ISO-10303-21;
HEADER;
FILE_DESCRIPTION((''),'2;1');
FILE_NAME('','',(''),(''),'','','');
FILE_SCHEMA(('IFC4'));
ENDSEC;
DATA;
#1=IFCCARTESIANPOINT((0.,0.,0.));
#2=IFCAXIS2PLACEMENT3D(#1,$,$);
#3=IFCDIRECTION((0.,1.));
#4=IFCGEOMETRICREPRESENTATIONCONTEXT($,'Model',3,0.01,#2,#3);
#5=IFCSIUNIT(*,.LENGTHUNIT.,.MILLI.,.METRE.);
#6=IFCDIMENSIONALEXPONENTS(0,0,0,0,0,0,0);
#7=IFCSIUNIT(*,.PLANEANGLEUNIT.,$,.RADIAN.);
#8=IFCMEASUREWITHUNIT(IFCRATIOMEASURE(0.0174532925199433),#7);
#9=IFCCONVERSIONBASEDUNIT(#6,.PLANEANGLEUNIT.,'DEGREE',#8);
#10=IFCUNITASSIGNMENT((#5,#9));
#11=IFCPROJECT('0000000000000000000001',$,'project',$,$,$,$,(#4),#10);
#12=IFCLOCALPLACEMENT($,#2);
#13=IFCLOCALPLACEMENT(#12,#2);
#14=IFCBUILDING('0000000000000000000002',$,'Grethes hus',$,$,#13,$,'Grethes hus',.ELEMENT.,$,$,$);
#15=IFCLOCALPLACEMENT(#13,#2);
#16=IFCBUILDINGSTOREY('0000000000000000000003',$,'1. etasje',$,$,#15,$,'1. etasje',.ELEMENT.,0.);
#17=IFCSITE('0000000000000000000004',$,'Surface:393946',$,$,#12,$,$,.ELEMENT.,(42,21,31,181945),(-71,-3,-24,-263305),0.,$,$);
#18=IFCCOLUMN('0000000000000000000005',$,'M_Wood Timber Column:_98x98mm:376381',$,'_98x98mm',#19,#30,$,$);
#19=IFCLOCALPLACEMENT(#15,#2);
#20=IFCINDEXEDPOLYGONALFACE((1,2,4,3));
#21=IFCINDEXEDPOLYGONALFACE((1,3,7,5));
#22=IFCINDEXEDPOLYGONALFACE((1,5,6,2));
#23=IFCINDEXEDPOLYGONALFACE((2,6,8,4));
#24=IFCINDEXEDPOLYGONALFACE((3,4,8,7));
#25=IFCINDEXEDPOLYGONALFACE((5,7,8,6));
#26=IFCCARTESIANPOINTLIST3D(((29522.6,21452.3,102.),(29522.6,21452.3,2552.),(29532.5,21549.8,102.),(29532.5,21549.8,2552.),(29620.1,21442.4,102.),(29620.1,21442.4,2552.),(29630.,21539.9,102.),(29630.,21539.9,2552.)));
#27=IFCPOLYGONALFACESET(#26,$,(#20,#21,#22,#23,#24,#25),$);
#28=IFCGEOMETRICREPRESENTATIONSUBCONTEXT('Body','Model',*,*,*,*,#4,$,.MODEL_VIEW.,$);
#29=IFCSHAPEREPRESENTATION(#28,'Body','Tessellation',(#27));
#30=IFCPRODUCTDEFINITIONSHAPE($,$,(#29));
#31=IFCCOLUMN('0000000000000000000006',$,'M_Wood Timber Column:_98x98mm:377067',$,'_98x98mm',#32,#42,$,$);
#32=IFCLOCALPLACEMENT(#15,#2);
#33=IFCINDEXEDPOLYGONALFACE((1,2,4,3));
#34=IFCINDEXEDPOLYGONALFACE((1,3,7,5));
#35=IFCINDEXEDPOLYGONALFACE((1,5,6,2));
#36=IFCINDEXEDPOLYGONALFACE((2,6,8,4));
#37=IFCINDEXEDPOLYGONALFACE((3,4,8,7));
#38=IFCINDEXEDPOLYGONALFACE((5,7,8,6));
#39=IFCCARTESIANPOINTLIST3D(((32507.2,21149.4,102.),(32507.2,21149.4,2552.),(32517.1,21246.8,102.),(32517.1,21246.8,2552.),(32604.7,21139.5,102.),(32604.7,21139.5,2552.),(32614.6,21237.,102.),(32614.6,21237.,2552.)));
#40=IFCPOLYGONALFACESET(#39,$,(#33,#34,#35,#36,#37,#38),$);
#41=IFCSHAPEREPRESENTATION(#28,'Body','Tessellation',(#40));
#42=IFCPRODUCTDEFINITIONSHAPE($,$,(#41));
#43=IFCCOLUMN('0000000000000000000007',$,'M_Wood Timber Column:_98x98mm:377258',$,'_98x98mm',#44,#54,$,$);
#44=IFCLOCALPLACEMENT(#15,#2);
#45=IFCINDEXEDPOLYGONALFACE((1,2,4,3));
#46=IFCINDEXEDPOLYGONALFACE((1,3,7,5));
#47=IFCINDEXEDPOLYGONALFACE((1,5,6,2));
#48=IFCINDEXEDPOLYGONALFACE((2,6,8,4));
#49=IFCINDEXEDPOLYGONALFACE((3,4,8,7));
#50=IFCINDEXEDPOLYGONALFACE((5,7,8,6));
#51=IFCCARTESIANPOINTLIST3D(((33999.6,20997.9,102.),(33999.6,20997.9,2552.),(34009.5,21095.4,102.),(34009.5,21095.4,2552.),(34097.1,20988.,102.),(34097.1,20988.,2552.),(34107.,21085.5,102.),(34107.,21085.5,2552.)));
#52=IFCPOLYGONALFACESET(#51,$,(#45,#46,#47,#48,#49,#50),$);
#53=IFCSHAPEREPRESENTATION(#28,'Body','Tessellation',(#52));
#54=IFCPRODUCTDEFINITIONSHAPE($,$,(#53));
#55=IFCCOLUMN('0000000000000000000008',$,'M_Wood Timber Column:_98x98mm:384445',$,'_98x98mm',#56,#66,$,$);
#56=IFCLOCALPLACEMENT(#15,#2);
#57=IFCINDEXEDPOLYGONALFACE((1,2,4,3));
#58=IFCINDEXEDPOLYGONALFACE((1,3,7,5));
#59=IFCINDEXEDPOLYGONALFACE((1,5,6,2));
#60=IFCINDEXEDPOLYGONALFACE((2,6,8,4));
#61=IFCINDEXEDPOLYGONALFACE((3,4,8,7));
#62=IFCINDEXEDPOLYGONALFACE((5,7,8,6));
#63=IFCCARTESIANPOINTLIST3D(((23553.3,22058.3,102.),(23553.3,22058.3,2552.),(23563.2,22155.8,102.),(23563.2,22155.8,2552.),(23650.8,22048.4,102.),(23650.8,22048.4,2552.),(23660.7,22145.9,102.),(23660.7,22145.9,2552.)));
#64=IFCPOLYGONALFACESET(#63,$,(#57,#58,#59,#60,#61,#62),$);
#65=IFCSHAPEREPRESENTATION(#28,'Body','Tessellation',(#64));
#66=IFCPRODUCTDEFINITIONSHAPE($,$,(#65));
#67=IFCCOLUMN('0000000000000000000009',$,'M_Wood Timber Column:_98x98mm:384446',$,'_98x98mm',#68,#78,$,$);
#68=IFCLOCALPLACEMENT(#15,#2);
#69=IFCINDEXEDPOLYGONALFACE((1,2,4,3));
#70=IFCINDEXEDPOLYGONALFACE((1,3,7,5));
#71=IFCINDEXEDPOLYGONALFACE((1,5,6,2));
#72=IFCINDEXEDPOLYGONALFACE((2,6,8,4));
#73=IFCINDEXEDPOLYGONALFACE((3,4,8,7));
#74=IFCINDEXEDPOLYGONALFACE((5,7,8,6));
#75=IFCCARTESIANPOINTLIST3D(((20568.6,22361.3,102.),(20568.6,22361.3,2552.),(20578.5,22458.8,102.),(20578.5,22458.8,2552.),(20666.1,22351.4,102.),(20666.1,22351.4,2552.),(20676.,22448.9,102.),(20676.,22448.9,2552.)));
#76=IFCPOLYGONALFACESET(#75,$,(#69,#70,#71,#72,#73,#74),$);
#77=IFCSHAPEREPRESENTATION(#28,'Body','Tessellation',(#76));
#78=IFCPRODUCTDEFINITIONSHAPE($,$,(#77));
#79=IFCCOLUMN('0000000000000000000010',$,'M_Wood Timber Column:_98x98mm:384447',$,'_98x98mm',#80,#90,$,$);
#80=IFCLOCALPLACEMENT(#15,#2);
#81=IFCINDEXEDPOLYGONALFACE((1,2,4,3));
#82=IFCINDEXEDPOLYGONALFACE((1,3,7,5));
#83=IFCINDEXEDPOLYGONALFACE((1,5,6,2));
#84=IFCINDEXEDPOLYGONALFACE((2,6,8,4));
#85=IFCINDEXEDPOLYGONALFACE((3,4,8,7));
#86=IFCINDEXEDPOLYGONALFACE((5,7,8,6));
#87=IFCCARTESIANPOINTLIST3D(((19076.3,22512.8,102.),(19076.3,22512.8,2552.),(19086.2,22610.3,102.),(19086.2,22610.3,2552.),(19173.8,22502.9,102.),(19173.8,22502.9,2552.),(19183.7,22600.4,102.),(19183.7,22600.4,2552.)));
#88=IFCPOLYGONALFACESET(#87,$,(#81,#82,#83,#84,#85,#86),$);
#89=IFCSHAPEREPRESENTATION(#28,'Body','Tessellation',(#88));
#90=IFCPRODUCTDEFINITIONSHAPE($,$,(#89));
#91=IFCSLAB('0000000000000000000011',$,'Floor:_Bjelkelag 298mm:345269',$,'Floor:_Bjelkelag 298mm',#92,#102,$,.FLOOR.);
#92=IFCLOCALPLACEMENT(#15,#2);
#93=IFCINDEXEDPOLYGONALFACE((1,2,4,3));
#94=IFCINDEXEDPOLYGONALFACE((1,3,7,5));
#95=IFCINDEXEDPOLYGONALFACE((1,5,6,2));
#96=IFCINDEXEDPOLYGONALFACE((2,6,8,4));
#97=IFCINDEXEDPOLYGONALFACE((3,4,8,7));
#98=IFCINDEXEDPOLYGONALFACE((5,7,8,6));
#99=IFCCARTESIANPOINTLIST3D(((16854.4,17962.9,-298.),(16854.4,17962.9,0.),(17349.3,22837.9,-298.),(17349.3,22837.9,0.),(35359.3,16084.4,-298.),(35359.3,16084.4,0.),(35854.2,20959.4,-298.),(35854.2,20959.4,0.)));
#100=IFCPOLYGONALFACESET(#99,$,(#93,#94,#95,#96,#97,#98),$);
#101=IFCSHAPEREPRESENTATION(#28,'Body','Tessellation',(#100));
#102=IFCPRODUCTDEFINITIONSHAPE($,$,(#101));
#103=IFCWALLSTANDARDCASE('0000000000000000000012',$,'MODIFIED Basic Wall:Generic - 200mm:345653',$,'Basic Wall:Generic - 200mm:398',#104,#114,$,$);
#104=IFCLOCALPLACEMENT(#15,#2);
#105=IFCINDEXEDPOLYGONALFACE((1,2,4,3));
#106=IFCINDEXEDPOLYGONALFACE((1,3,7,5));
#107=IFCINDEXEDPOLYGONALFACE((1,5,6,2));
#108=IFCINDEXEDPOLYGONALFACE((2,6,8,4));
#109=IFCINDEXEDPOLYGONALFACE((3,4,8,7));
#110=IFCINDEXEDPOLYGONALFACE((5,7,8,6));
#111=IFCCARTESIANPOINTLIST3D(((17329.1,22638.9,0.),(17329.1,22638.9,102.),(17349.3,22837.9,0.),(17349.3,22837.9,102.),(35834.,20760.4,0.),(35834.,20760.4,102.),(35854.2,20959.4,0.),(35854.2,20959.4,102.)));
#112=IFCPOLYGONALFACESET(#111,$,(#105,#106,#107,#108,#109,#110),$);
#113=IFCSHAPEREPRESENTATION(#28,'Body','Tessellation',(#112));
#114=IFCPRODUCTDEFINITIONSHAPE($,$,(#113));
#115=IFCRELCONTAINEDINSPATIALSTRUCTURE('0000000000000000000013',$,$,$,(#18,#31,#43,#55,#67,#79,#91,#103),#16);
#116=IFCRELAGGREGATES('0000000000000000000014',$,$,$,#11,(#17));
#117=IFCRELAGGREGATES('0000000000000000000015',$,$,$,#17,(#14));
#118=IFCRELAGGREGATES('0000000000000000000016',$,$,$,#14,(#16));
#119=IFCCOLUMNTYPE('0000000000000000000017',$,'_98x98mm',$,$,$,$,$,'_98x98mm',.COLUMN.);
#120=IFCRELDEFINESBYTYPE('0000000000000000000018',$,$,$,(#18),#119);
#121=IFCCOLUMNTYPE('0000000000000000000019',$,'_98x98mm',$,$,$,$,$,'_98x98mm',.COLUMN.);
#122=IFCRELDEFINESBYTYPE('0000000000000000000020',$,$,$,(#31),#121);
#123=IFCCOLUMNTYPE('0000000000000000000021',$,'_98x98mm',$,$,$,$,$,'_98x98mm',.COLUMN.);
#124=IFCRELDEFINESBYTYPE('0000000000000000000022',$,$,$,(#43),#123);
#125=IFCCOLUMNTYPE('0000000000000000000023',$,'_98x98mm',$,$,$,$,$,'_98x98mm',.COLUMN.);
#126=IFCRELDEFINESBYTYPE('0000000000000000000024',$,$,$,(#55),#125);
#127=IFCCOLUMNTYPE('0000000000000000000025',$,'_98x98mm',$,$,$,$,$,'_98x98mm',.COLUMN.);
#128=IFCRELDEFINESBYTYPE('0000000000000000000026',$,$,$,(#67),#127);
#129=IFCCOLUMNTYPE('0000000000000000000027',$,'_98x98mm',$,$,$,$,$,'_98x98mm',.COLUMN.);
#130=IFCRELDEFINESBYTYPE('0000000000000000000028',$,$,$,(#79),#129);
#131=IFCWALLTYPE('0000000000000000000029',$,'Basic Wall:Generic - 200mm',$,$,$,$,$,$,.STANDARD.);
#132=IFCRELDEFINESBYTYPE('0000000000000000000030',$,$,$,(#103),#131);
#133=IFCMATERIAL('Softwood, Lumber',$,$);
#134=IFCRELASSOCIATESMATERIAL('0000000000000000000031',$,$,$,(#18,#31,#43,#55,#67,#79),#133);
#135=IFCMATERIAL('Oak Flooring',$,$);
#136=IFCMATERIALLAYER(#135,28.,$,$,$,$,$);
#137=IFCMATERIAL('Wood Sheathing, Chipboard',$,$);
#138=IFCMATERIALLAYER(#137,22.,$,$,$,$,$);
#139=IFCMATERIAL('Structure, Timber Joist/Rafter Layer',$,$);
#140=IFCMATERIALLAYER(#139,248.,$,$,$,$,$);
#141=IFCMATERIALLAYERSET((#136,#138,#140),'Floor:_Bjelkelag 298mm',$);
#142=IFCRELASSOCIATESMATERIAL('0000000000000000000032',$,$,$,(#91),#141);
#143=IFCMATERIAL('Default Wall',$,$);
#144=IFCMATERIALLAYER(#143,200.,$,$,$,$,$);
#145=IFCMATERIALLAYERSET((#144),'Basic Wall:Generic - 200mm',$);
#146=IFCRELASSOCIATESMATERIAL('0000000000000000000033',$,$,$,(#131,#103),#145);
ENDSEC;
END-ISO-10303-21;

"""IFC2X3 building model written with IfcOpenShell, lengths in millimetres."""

from ifc_helpers import new_model, entity, si_unit, converted_unit, direction, frame, frame_2d, origin, place, context, subcontext, project, spatial, rectangle, extrude, source, transform, mapped, material, layer, layer_set, layer_usage, type_object, type_shapes, element, save


model = new_model("IFC2X3")

# Units and contexts
model_context = context("Model", 3, precision=0.01, world=origin(), true_north=direction((0.0, 1.0)))
body_context = subcontext(model_context, "Body", "Model", "MODEL_VIEW")
ifc_project = project(units=[si_unit("LENGTHUNIT", "METRE", prefix="MILLI"), converted_unit("PLANEANGLEUNIT", "DEGREE", entity("IfcRatioMeasure", 0.0174532925199433), si_unit("PLANEANGLEUNIT", "RADIAN"), dimensions=[0, 0, 0, 0, 0, 0, 0])], contexts=[model_context])

# Site, building, storey
site_placement = place(None, origin())
site = spatial("IfcSite", under=ifc_project, at=site_placement, Name="Surface:393946", CompositionType="ELEMENT", RefLatitude=(42, 21, 31, 181945), RefLongitude=(-71, -3, -24, -263305), RefElevation=0.0)
building_placement = place(site_placement, origin())
building = spatial("IfcBuilding", under=site, at=building_placement, Name="Grethes hus", LongName="Grethes hus", CompositionType="ELEMENT")
storey_placement = place(building_placement, origin())
storey = spatial("IfcBuildingStorey", under=building, at=storey_placement, Name="1. etasje", LongName="1. etasje", CompositionType="ELEMENT", Elevation=0.0)

# Columns
ifc_material_1 = material(Name="Softwood, Lumber")
column_type_1 = type_object("IfcColumnType", Name="_98x98mm", ElementType="_98x98mm", PredefinedType="COLUMN")
shared_shape_1 = source(origin(), body_context, "Body", "SweptSolid", [
    extrude(rectangle(XDim=98.0, YDim=98.0, at=frame_2d((0.0, 0.0), x_axis=(1.0, 0.0))), frame((29576.3, 21496.1, 102.0), z_axis=(0.0, 0.0, 1.0), x_axis=(0.100996, 0.994887, 0.0)), (0.0, 0.0, 1.0), 2450.0),
])
type_shapes(column_type_1, [shared_shape_1])
column_1_placement = place(storey_placement, origin())
element("IfcColumn", 1, at=column_1_placement, inside=storey, type_object=column_type_1, material=ifc_material_1, Name="M_Wood Timber Column:_98x98mm:376381", ObjectType="_98x98mm", context=body_context, shape_type="MappedRepresentation", body=[
    mapped(shared_shape_1, transform((0.0, 0.0, 0.0), scale=1.0)),
])
column_type_2 = type_object("IfcColumnType", Name="_98x98mm", ElementType="_98x98mm", PredefinedType="COLUMN")
shared_shape_2 = source(origin(), body_context, "Body", "SweptSolid", [
    extrude(rectangle(XDim=98.0, YDim=98.0, at=frame_2d((0.0, 0.0), x_axis=(1.0, 0.0))), frame((32560.9, 21193.2, 102.0), z_axis=(0.0, 0.0, 1.0), x_axis=(0.100996, 0.994887, 0.0)), (0.0, 0.0, 1.0), 2450.0),
])
type_shapes(column_type_2, [shared_shape_2])
column_2_placement = place(storey_placement, origin())
element("IfcColumn", 2, at=column_2_placement, inside=storey, type_object=column_type_2, material=ifc_material_1, Name="M_Wood Timber Column:_98x98mm:377067", ObjectType="_98x98mm", context=body_context, shape_type="MappedRepresentation", body=[
    mapped(shared_shape_2, transform((0.0, 0.0, 0.0), scale=1.0)),
])
column_type_3 = type_object("IfcColumnType", Name="_98x98mm", ElementType="_98x98mm", PredefinedType="COLUMN")
shared_shape_3 = source(origin(), body_context, "Body", "SweptSolid", [
    extrude(rectangle(XDim=98.0, YDim=98.0, at=frame_2d((0.0, 0.0), x_axis=(1.0, 0.0))), frame((34053.3, 21041.7, 102.0), z_axis=(0.0, 0.0, 1.0), x_axis=(0.100996, 0.994887, 0.0)), (0.0, 0.0, 1.0), 2450.0),
])
type_shapes(column_type_3, [shared_shape_3])
column_3_placement = place(storey_placement, origin())
element("IfcColumn", 3, at=column_3_placement, inside=storey, type_object=column_type_3, material=ifc_material_1, Name="M_Wood Timber Column:_98x98mm:377258", ObjectType="_98x98mm", context=body_context, shape_type="MappedRepresentation", body=[
    mapped(shared_shape_3, transform((0.0, 0.0, 0.0), scale=1.0)),
])
column_type_4 = type_object("IfcColumnType", Name="_98x98mm", ElementType="_98x98mm", PredefinedType="COLUMN")
shared_shape_4 = source(origin(), body_context, "Body", "SweptSolid", [
    extrude(rectangle(XDim=98.0, YDim=98.0, at=frame_2d((0.0, 0.0), x_axis=(1.0, 0.0))), frame((23607.0, 22102.1, 102.0), z_axis=(0.0, 0.0, 1.0), x_axis=(0.100996, 0.994887, 0.0)), (0.0, 0.0, 1.0), 2450.0),
])
type_shapes(column_type_4, [shared_shape_4])
column_4_placement = place(storey_placement, origin())
element("IfcColumn", 4, at=column_4_placement, inside=storey, type_object=column_type_4, material=ifc_material_1, Name="M_Wood Timber Column:_98x98mm:384445", ObjectType="_98x98mm", context=body_context, shape_type="MappedRepresentation", body=[
    mapped(shared_shape_4, transform((0.0, 0.0, 0.0), scale=1.0)),
])
column_type_5 = type_object("IfcColumnType", Name="_98x98mm", ElementType="_98x98mm", PredefinedType="COLUMN")
shared_shape_5 = source(origin(), body_context, "Body", "SweptSolid", [
    extrude(rectangle(XDim=98.0, YDim=98.0, at=frame_2d((0.0, 0.0), x_axis=(1.0, 0.0))), frame((20622.3, 22405.1, 102.0), z_axis=(0.0, 0.0, 1.0), x_axis=(0.100996, 0.994887, 0.0)), (0.0, 0.0, 1.0), 2450.0),
])
type_shapes(column_type_5, [shared_shape_5])
column_5_placement = place(storey_placement, origin())
element("IfcColumn", 5, at=column_5_placement, inside=storey, type_object=column_type_5, material=ifc_material_1, Name="M_Wood Timber Column:_98x98mm:384446", ObjectType="_98x98mm", context=body_context, shape_type="MappedRepresentation", body=[
    mapped(shared_shape_5, transform((0.0, 0.0, 0.0), scale=1.0)),
])
column_type_6 = type_object("IfcColumnType", Name="_98x98mm", ElementType="_98x98mm", PredefinedType="COLUMN")
shared_shape_6 = source(origin(), body_context, "Body", "SweptSolid", [
    extrude(rectangle(XDim=98.0, YDim=98.0, at=frame_2d((0.0, 0.0), x_axis=(1.0, 0.0))), frame((19130.0, 22556.6, 102.0), z_axis=(0.0, 0.0, 1.0), x_axis=(0.100996, 0.994887, 0.0)), (0.0, 0.0, 1.0), 2450.0),
])
type_shapes(column_type_6, [shared_shape_6])
column_6_placement = place(storey_placement, origin())
element("IfcColumn", 6, at=column_6_placement, inside=storey, type_object=column_type_6, material=ifc_material_1, Name="M_Wood Timber Column:_98x98mm:384447", ObjectType="_98x98mm", context=body_context, shape_type="MappedRepresentation", body=[
    mapped(shared_shape_6, transform((0.0, 0.0, 0.0), scale=1.0)),
])

# Slab
ifc_material_2 = material(Name="Oak Flooring")
ifc_layer_1 = layer(ifc_material_2, 28.0)
ifc_material_3 = material(Name="Wood Sheathing, Chipboard")
ifc_layer_2 = layer(ifc_material_3, 22.0)
ifc_material_4 = material(Name="Structure, Timber Joist/Rafter Layer")
ifc_layer_3 = layer(ifc_material_4, 248.0)
ifc_layer_set_1 = layer_set([ifc_layer_1, ifc_layer_2, ifc_layer_3], Name="Floor:_Bjelkelag 298mm")
ifc_layer_usage_1 = layer_usage(ifc_layer_set_1, "AXIS3", "POSITIVE", 0.0)
slab_1_placement = place(storey_placement, origin())
element("IfcSlab", 7, at=slab_1_placement, inside=storey, material=ifc_layer_usage_1, Name="Floor:_Bjelkelag 298mm:345269", ObjectType="Floor:_Bjelkelag 298mm", PredefinedType="FLOOR", context=body_context, shape_type="SweptSolid", body=[
    extrude(rectangle(XDim=18600.0, YDim=4900.0, at=frame_2d((0.0, 0.0), x_axis=(1.0, 0.0))), frame((26354.3, 19461.1, 0.0), z_axis=(0.0, 0.0, -1.0), x_axis=(0.994887, -0.100996, 0.0)), (0.0, 0.0, 1.0), 298.0),
])

# Wall
ifc_material_5 = material(Name="Default Wall")
ifc_layer_4 = layer(ifc_material_5, 200.0)
ifc_layer_set_2 = layer_set([ifc_layer_4], Name="Basic Wall:Generic - 200mm")
ifc_layer_usage_2 = layer_usage(ifc_layer_set_2, "AXIS2", "NEGATIVE", 100.0)
wall_type_1 = type_object("IfcWallType", Name="Basic Wall:Generic - 200mm", PredefinedType="STANDARD", material=ifc_layer_set_2)
wall_1_placement = place(storey_placement, frame((17339.2, 22738.4, 0.0), z_axis=(0.0, 0.0, 1.0), x_axis=(0.994887, -0.100996, 0.0)))
element("IfcWallStandardCase", 8, at=wall_1_placement, inside=storey, type_object=wall_type_1, material=ifc_layer_usage_2, Name="MODIFIED Basic Wall:Generic - 200mm:345653", ObjectType="Basic Wall:Generic - 200mm:398", context=body_context, shape_type="SweptSolid", body=[
    extrude(rectangle(XDim=18600.0, YDim=200.0, at=frame_2d((9300.0, 0.0), x_axis=(-1.0, 0.0))), origin(), (0.0, 0.0, 1.0), 102.0),
])

save(model, "model.ifc")
